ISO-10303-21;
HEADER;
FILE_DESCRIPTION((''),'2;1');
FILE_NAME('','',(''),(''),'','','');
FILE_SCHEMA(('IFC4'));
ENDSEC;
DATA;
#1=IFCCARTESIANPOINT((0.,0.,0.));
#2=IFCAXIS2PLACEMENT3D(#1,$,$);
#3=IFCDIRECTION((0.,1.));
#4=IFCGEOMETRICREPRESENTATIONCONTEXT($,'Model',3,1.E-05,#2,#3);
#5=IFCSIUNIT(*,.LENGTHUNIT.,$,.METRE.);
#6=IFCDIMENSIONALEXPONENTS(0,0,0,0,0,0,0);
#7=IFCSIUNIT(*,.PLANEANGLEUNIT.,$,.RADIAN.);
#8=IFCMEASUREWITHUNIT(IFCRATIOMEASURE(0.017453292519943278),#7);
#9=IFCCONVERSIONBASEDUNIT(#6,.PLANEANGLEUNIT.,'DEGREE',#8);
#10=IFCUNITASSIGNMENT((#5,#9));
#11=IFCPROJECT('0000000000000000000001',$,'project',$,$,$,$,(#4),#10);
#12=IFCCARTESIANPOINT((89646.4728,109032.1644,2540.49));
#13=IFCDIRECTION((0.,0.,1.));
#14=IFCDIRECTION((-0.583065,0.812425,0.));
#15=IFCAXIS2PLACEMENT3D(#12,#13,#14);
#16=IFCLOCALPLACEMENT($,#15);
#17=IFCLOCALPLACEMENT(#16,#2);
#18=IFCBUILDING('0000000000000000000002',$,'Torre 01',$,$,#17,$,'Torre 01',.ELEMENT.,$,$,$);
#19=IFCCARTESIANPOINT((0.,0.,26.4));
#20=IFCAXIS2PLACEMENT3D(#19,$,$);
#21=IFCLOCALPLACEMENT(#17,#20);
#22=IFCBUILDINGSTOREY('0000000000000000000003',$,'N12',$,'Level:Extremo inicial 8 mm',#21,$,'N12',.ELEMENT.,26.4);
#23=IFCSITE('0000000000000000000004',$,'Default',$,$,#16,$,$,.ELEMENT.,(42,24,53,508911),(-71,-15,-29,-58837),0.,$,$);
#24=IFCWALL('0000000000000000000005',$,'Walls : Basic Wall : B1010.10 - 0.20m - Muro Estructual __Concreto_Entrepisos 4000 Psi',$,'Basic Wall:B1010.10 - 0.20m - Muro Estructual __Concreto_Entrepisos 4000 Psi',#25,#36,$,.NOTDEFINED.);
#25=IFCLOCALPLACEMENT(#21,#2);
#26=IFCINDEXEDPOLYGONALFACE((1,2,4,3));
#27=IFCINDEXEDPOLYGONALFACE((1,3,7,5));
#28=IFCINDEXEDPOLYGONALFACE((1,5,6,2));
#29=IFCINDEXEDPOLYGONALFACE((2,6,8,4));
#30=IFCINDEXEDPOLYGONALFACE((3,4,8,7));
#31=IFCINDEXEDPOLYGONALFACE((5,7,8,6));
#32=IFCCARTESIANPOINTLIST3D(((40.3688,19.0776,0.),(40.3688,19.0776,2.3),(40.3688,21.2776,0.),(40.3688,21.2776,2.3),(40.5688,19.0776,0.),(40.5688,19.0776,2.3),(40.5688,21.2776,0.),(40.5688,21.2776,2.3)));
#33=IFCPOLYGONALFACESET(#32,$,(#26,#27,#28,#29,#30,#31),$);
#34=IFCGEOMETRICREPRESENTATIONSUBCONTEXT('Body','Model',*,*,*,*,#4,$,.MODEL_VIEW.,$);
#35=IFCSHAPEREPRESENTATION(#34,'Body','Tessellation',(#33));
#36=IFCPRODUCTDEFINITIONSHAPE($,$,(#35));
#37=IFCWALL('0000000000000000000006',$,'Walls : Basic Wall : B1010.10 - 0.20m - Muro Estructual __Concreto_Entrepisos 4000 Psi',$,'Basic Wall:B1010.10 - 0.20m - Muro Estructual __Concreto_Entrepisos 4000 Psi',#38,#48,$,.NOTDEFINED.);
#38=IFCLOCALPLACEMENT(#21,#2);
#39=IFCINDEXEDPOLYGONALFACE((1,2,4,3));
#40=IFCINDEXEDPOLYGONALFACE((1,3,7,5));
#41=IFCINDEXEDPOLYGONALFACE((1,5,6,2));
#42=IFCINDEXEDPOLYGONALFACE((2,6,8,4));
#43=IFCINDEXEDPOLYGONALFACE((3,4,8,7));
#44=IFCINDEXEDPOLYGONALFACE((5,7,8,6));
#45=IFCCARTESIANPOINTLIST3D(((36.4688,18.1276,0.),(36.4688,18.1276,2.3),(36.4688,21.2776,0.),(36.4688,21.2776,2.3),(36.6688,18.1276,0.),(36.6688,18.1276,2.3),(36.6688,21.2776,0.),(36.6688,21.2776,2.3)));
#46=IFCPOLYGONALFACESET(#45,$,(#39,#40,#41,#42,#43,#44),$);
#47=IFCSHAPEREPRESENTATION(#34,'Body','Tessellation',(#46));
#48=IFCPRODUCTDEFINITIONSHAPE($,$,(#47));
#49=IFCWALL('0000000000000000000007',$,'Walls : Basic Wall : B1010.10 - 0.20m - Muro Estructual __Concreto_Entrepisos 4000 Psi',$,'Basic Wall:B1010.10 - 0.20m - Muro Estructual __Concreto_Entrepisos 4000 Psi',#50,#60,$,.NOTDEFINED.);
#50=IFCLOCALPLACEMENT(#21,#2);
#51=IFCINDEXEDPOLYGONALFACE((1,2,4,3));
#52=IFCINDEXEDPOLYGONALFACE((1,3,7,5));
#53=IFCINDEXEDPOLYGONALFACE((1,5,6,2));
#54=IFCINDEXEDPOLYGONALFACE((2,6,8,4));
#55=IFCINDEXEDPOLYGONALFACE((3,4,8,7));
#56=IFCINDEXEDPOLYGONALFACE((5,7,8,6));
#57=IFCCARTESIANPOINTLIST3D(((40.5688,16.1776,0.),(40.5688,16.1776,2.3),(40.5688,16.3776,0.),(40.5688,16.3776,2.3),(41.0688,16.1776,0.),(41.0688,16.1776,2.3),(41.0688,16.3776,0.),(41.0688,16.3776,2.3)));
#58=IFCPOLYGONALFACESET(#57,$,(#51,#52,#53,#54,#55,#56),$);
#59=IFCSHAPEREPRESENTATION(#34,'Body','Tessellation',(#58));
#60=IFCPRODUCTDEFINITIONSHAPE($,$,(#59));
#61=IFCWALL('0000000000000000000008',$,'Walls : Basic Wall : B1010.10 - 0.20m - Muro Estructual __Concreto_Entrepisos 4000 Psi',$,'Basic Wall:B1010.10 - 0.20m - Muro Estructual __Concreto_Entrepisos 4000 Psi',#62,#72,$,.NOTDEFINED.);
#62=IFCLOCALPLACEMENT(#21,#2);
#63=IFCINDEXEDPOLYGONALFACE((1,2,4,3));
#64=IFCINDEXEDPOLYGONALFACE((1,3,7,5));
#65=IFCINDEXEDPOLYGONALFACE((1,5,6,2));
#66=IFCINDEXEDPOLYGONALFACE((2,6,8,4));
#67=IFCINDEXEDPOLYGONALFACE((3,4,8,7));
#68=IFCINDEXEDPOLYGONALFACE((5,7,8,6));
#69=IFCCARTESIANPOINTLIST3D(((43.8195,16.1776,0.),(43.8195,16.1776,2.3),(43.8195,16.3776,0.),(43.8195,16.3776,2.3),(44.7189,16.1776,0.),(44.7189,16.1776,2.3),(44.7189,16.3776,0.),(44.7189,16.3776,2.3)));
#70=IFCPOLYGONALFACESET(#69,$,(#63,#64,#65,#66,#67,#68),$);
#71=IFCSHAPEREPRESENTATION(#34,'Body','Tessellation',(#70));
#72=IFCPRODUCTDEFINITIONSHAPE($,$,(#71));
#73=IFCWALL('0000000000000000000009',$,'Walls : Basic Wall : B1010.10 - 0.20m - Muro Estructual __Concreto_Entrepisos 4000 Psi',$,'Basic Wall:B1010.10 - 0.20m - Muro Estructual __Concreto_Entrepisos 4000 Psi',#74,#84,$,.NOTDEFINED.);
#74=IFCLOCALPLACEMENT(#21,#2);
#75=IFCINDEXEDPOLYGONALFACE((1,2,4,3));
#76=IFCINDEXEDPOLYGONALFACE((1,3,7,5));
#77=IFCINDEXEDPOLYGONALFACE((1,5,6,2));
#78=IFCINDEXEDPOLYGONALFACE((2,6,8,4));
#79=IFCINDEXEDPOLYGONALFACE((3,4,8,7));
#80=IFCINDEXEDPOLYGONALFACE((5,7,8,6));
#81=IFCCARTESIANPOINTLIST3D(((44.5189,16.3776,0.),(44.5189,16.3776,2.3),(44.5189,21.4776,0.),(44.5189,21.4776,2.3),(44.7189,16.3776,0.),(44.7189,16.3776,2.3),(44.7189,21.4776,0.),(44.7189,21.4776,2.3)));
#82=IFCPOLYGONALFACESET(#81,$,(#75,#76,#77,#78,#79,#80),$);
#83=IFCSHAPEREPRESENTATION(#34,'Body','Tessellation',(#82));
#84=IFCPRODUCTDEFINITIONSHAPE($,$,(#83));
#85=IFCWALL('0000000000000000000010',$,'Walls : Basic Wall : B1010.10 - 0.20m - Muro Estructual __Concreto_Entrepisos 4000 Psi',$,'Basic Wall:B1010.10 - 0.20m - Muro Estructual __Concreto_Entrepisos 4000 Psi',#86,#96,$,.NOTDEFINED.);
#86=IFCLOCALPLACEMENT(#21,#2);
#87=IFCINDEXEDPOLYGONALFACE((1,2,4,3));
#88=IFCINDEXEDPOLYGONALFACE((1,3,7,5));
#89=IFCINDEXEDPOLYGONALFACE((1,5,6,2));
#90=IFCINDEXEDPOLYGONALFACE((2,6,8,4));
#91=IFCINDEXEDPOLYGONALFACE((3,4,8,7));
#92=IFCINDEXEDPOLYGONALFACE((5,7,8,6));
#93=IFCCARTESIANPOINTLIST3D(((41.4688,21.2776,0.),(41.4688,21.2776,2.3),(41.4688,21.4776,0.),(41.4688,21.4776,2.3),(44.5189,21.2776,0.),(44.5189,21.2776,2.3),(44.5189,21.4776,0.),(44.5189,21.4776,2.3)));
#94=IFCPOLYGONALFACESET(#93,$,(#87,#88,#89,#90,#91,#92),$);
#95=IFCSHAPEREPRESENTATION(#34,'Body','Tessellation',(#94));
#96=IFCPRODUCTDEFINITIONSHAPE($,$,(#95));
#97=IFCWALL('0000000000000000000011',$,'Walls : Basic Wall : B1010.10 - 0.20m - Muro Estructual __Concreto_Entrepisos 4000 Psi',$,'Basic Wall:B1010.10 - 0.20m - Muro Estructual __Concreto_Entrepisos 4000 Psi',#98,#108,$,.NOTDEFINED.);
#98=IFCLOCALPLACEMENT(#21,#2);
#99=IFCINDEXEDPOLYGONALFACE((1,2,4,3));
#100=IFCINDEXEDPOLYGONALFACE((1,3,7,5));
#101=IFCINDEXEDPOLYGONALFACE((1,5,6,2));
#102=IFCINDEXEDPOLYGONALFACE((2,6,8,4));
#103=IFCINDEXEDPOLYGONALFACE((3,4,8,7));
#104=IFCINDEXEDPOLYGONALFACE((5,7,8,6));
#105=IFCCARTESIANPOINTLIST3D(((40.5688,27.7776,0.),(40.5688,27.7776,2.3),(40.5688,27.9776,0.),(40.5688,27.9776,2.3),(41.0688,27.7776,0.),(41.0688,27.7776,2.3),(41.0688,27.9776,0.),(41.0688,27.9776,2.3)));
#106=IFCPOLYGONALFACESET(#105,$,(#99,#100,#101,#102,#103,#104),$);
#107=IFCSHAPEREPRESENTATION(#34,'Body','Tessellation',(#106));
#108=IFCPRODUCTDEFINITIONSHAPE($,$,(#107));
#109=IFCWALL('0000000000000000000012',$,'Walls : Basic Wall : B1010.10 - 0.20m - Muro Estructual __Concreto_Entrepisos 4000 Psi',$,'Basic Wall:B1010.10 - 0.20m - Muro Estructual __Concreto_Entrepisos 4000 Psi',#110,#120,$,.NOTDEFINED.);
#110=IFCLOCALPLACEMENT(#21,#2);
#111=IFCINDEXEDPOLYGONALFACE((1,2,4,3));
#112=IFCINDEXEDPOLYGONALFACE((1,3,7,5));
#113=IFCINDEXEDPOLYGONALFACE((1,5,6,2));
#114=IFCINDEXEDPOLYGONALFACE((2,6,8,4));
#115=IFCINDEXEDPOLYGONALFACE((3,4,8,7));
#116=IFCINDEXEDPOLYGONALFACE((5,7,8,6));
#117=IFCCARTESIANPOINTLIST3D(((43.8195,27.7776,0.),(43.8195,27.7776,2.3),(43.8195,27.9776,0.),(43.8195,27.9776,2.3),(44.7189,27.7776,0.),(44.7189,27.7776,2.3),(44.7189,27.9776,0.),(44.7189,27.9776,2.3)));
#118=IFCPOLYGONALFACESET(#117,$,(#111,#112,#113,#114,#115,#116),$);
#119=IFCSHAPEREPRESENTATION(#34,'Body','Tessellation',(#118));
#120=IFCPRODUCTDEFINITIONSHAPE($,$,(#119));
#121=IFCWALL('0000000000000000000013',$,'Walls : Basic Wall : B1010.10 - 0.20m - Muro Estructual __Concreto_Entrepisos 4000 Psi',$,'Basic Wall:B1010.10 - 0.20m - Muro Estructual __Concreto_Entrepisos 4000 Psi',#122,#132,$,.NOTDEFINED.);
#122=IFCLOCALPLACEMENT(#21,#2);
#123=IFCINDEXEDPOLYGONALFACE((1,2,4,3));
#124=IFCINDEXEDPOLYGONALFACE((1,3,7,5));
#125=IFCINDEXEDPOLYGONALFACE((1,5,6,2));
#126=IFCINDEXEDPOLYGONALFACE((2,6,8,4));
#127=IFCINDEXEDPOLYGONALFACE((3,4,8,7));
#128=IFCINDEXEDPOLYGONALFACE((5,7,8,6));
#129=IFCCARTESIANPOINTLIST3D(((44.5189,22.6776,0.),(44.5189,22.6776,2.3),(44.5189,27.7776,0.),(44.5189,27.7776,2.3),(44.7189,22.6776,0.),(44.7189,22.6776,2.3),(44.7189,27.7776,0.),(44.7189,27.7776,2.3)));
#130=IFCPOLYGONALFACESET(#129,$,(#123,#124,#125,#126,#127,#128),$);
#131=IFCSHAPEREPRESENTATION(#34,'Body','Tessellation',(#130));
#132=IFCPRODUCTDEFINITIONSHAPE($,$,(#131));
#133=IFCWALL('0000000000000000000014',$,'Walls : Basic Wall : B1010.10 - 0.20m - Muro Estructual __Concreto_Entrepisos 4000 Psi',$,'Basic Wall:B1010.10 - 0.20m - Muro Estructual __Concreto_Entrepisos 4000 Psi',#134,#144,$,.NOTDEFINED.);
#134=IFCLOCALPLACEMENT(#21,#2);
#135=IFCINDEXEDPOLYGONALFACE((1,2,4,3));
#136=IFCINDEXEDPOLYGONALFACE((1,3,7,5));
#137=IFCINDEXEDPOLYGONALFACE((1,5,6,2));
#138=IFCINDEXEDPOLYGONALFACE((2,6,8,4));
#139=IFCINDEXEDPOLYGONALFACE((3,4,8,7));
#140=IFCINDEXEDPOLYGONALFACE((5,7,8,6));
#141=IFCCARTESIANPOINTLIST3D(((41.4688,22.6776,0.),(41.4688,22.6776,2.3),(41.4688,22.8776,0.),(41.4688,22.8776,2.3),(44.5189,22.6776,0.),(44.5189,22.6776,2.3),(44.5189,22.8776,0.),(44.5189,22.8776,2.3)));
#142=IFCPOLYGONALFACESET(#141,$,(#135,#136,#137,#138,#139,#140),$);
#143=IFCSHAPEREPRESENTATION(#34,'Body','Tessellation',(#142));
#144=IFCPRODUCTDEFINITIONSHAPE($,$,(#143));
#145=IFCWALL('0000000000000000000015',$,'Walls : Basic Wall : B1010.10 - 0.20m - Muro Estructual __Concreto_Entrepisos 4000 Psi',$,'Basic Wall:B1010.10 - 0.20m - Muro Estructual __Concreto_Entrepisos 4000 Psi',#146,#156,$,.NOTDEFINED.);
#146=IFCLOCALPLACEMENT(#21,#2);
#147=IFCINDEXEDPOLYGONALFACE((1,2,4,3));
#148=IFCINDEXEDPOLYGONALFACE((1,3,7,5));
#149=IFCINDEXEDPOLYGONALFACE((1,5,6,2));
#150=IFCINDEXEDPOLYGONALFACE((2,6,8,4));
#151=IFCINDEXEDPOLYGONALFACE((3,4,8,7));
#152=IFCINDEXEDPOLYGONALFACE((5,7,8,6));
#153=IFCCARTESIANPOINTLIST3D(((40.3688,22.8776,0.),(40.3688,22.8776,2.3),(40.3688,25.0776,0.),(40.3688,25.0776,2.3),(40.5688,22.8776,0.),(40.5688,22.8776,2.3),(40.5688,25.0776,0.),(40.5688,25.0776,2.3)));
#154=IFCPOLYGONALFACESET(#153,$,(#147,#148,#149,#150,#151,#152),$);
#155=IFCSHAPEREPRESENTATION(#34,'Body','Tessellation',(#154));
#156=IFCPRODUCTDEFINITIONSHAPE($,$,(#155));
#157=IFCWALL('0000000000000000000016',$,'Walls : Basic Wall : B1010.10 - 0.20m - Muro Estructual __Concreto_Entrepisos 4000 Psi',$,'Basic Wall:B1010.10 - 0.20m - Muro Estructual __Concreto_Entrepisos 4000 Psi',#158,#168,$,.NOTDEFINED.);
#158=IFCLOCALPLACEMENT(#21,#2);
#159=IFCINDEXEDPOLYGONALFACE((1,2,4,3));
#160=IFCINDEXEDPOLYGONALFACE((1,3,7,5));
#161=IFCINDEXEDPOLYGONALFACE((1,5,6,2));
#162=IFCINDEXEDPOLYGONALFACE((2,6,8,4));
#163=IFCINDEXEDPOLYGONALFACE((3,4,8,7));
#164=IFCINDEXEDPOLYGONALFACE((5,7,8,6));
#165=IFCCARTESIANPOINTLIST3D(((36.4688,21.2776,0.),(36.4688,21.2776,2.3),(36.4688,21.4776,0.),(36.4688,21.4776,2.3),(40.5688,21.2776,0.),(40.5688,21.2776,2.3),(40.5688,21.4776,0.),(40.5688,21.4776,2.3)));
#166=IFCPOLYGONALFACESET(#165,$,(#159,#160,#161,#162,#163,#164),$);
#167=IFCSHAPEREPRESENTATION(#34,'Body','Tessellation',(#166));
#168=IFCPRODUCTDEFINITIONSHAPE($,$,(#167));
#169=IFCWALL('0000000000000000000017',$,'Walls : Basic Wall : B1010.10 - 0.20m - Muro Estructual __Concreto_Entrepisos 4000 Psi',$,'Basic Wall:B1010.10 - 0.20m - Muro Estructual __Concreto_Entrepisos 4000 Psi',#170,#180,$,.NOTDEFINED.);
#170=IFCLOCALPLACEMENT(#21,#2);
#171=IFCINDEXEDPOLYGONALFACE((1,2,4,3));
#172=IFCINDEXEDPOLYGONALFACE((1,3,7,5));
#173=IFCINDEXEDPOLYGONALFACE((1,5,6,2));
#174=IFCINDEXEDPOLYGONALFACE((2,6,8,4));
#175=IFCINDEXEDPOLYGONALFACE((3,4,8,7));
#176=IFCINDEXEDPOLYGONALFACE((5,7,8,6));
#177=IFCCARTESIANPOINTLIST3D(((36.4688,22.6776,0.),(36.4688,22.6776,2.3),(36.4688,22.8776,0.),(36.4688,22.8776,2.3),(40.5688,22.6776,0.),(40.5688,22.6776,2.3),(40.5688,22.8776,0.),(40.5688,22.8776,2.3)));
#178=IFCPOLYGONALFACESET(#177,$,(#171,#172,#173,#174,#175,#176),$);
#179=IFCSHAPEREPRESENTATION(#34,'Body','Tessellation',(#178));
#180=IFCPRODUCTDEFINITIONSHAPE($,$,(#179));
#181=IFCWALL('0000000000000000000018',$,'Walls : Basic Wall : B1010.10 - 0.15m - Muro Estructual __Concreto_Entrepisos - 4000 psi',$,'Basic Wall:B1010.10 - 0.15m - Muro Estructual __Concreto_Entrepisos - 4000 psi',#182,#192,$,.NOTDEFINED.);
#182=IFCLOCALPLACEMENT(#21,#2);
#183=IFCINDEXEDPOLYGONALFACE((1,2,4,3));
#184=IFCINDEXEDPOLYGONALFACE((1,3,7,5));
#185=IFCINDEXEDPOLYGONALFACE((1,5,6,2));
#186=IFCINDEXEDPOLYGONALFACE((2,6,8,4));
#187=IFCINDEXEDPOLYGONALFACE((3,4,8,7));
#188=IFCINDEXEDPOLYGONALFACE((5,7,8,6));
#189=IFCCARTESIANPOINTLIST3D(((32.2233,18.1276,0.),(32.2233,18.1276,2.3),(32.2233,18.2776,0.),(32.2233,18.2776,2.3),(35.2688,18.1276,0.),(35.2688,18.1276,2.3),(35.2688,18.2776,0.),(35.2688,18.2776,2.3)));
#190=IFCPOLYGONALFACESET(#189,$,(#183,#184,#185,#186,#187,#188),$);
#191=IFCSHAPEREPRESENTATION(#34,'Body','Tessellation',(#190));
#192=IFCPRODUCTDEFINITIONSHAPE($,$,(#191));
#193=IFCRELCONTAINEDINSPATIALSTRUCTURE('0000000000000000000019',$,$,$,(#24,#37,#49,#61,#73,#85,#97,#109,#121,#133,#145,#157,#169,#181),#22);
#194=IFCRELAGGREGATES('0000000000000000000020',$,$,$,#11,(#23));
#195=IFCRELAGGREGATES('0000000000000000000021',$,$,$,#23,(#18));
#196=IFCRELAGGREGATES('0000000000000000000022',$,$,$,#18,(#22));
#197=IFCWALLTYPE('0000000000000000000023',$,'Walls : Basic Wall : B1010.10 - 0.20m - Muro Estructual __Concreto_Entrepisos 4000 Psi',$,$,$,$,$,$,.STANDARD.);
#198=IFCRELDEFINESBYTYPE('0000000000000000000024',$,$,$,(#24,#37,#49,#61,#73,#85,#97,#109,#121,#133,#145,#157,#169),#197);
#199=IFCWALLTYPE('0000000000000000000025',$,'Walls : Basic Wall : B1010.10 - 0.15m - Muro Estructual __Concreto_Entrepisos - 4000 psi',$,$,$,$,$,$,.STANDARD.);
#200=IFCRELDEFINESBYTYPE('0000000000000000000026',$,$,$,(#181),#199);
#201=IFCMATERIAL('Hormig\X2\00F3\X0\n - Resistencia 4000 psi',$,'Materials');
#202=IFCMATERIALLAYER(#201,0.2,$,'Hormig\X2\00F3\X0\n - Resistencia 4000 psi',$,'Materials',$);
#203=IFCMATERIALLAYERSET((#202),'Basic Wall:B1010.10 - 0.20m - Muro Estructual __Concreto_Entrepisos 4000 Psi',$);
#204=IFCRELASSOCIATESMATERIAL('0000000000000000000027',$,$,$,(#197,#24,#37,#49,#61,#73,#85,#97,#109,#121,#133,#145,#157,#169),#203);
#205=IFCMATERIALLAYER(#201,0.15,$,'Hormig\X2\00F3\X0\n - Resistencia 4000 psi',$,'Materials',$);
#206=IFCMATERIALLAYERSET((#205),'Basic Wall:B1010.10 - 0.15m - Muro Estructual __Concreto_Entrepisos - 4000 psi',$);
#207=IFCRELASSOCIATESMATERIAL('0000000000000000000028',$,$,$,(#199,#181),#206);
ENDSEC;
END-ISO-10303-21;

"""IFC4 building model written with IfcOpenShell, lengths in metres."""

from ifc_helpers import new_model, entity, si_unit, converted_unit, direction, frame, frame_2d, origin, place, context, subcontext, project, spatial, rectangle, extrude, material, layer, layer_set, layer_usage, type_object, element, save


model = new_model("IFC4")

# Units and contexts
model_context = context("Model", 3, precision=1e-05, world=origin(), true_north=direction((0.0, 1.0)))
body_context = subcontext(model_context, "Body", "Model", "MODEL_VIEW")
ifc_project = project(units=[si_unit("LENGTHUNIT", "METRE"), converted_unit("PLANEANGLEUNIT", "DEGREE", entity("IfcRatioMeasure", 0.017453292519943278), si_unit("PLANEANGLEUNIT", "RADIAN"), dimensions=[0, 0, 0, 0, 0, 0, 0])], contexts=[model_context])

# Site, building, storey
site_placement = place(None, frame((89646.4728, 109032.1644, 2540.49), z_axis=(0.0, 0.0, 1.0), x_axis=(-0.583065, 0.812425, 0.0)))
site = spatial("IfcSite", under=ifc_project, at=site_placement, Name="Default", CompositionType="ELEMENT", RefLatitude=(42, 24, 53, 508911), RefLongitude=(-71, -15, -29, -58837), RefElevation=0.0)
building_placement = place(site_placement, origin())
building = spatial("IfcBuilding", under=site, at=building_placement, Name="Torre 01", LongName="Torre 01", CompositionType="ELEMENT")
storey_placement = place(building_placement, frame((0.0, 0.0, 26.4)))
storey = spatial("IfcBuildingStorey", under=building, at=storey_placement, Name="N12", ObjectType="Level:Extremo inicial 8 mm", LongName="N12", CompositionType="ELEMENT", Elevation=26.4)

# Walls
ifc_material = material(Name="Hormigón - Resistencia 4000 psi", Category="Materials")
ifc_layer_1 = layer(ifc_material, 0.2, Name="Hormigón - Resistencia 4000 psi", Category="Materials")
ifc_layer_set_1 = layer_set([ifc_layer_1], Name="Basic Wall:B1010.10 - 0.20m - Muro Estructual __Concreto_Entrepisos 4000 Psi")
ifc_layer_usage_1 = layer_usage(ifc_layer_set_1, "AXIS2", "NEGATIVE", 0.1)
wall_type_1 = type_object("IfcWallType", Name="Walls : Basic Wall : B1010.10 - 0.20m - Muro Estructual __Concreto_Entrepisos 4000 Psi", PredefinedType="STANDARD", material=ifc_layer_set_1)
wall_1_placement = place(storey_placement, frame((40.4688, 21.2776, 0.0), z_axis=(0.0, 0.0, 1.0), x_axis=(0.0, -1.0, 0.0)))
element("IfcWall", 1, at=wall_1_placement, inside=storey, type_object=wall_type_1, material=ifc_layer_usage_1, Name="Walls : Basic Wall : B1010.10 - 0.20m - Muro Estructual __Concreto_Entrepisos 4000 Psi", ObjectType="Basic Wall:B1010.10 - 0.20m - Muro Estructual __Concreto_Entrepisos 4000 Psi", PredefinedType="NOTDEFINED", context=body_context, shape_type="SweptSolid", body=[
    extrude(rectangle(XDim=2.2, YDim=0.2, at=frame_2d((1.1, 0.0), x_axis=(-1.0, 0.0))), origin(), (0.0, 0.0, 1.0), 2.3),
])
ifc_layer_usage_2 = layer_usage(ifc_layer_set_1, "AXIS2", "NEGATIVE", 0.1)
wall_2_placement = place(storey_placement, frame((36.5688, 18.1276, 0.0), z_axis=(0.0, 0.0, 1.0), x_axis=(0.0, 1.0, 0.0)))
element("IfcWall", 2, at=wall_2_placement, inside=storey, type_object=wall_type_1, material=ifc_layer_usage_2, Name="Walls : Basic Wall : B1010.10 - 0.20m - Muro Estructual __Concreto_Entrepisos 4000 Psi", ObjectType="Basic Wall:B1010.10 - 0.20m - Muro Estructual __Concreto_Entrepisos 4000 Psi", PredefinedType="NOTDEFINED", context=body_context, shape_type="SweptSolid", body=[
    extrude(rectangle(XDim=3.15, YDim=0.2, at=frame_2d((1.575, 0.0), x_axis=(-1.0, 0.0))), origin(), (0.0, 0.0, 1.0), 2.3),
])
ifc_layer_usage_3 = layer_usage(ifc_layer_set_1, "AXIS2", "NEGATIVE", 0.1)
wall_3_placement = place(storey_placement, frame((41.0688, 16.2776, 0.0), z_axis=(0.0, 0.0, 1.0), x_axis=(-1.0, 0.0, 0.0)))
element("IfcWall", 3, at=wall_3_placement, inside=storey, type_object=wall_type_1, material=ifc_layer_usage_3, Name="Walls : Basic Wall : B1010.10 - 0.20m - Muro Estructual __Concreto_Entrepisos 4000 Psi", ObjectType="Basic Wall:B1010.10 - 0.20m - Muro Estructual __Concreto_Entrepisos 4000 Psi", PredefinedType="NOTDEFINED", context=body_context, shape_type="SweptSolid", body=[
    extrude(rectangle(XDim=0.5, YDim=0.2, at=frame_2d((0.25, 0.0), x_axis=(-1.0, 0.0))), origin(), (0.0, 0.0, 1.0), 2.3),
])
ifc_layer_usage_4 = layer_usage(ifc_layer_set_1, "AXIS2", "NEGATIVE", 0.1)
wall_4_placement = place(storey_placement, frame((43.8195, 16.2776, 0.0)))
element("IfcWall", 4, at=wall_4_placement, inside=storey, type_object=wall_type_1, material=ifc_layer_usage_4, Name="Walls : Basic Wall : B1010.10 - 0.20m - Muro Estructual __Concreto_Entrepisos 4000 Psi", ObjectType="Basic Wall:B1010.10 - 0.20m - Muro Estructual __Concreto_Entrepisos 4000 Psi", PredefinedType="NOTDEFINED", context=body_context, shape_type="SweptSolid", body=[
    extrude(rectangle(XDim=0.8993, YDim=0.2, at=frame_2d((0.4497, 0.0), x_axis=(-1.0, 0.0))), origin(), (0.0, 0.0, 1.0), 2.3),
])
ifc_layer_usage_5 = layer_usage(ifc_layer_set_1, "AXIS2", "NEGATIVE", 0.1)
wall_5_placement = place(storey_placement, frame((44.6189, 21.4776, 0.0), z_axis=(0.0, 0.0, 1.0), x_axis=(0.0, -1.0, 0.0)))
element("IfcWall", 5, at=wall_5_placement, inside=storey, type_object=wall_type_1, material=ifc_layer_usage_5, Name="Walls : Basic Wall : B1010.10 - 0.20m - Muro Estructual __Concreto_Entrepisos 4000 Psi", ObjectType="Basic Wall:B1010.10 - 0.20m - Muro Estructual __Concreto_Entrepisos 4000 Psi", PredefinedType="NOTDEFINED", context=body_context, shape_type="SweptSolid", body=[
    extrude(rectangle(XDim=5.1, YDim=0.2, at=frame_2d((2.55, 0.0), x_axis=(-1.0, 0.0))), origin(), (0.0, 0.0, 1.0), 2.3),
])
ifc_layer_usage_6 = layer_usage(ifc_layer_set_1, "AXIS2", "NEGATIVE", 0.1)
wall_6_placement = place(storey_placement, frame((41.4688, 21.3776, 0.0)))
element("IfcWall", 6, at=wall_6_placement, inside=storey, type_object=wall_type_1, material=ifc_layer_usage_6, Name="Walls : Basic Wall : B1010.10 - 0.20m - Muro Estructual __Concreto_Entrepisos 4000 Psi", ObjectType="Basic Wall:B1010.10 - 0.20m - Muro Estructual __Concreto_Entrepisos 4000 Psi", PredefinedType="NOTDEFINED", context=body_context, shape_type="SweptSolid", body=[
    extrude(rectangle(XDim=3.05, YDim=0.2, at=frame_2d((1.525, 0.0), x_axis=(-1.0, 0.0))), origin(), (0.0, 0.0, 1.0), 2.3),
])
ifc_layer_usage_7 = layer_usage(ifc_layer_set_1, "AXIS2", "POSITIVE", -0.1)
wall_7_placement = place(storey_placement, frame((41.0688, 27.8776, 0.0), z_axis=(0.0, 0.0, 1.0), x_axis=(-1.0, 0.0, 0.0)))
element("IfcWall", 7, at=wall_7_placement, inside=storey, type_object=wall_type_1, material=ifc_layer_usage_7, Name="Walls : Basic Wall : B1010.10 - 0.20m - Muro Estructual __Concreto_Entrepisos 4000 Psi", ObjectType="Basic Wall:B1010.10 - 0.20m - Muro Estructual __Concreto_Entrepisos 4000 Psi", PredefinedType="NOTDEFINED", context=body_context, shape_type="SweptSolid", body=[
    extrude(rectangle(XDim=0.5, YDim=0.2, at=frame_2d((0.25, 0.0), x_axis=(-1.0, 0.0))), origin(), (0.0, 0.0, 1.0), 2.3),
])
ifc_layer_usage_8 = layer_usage(ifc_layer_set_1, "AXIS2", "POSITIVE", -0.1)
wall_8_placement = place(storey_placement, frame((43.8195, 27.8776, 0.0)))
element("IfcWall", 8, at=wall_8_placement, inside=storey, type_object=wall_type_1, material=ifc_layer_usage_8, Name="Walls : Basic Wall : B1010.10 - 0.20m - Muro Estructual __Concreto_Entrepisos 4000 Psi", ObjectType="Basic Wall:B1010.10 - 0.20m - Muro Estructual __Concreto_Entrepisos 4000 Psi", PredefinedType="NOTDEFINED", context=body_context, shape_type="SweptSolid", body=[
    extrude(rectangle(XDim=0.8993, YDim=0.2, at=frame_2d((0.4497, 0.0), x_axis=(-1.0, 0.0))), origin(), (0.0, 0.0, 1.0), 2.3),
])
ifc_layer_usage_9 = layer_usage(ifc_layer_set_1, "AXIS2", "POSITIVE", -0.1)
wall_9_placement = place(storey_placement, frame((44.6189, 22.6776, 0.0), z_axis=(0.0, 0.0, 1.0), x_axis=(0.0, 1.0, 0.0)))
element("IfcWall", 9, at=wall_9_placement, inside=storey, type_object=wall_type_1, material=ifc_layer_usage_9, Name="Walls : Basic Wall : B1010.10 - 0.20m - Muro Estructual __Concreto_Entrepisos 4000 Psi", ObjectType="Basic Wall:B1010.10 - 0.20m - Muro Estructual __Concreto_Entrepisos 4000 Psi", PredefinedType="NOTDEFINED", context=body_context, shape_type="SweptSolid", body=[
    extrude(rectangle(XDim=5.1, YDim=0.2, at=frame_2d((2.55, 0.0), x_axis=(-1.0, 0.0))), origin(), (0.0, 0.0, 1.0), 2.3),
])
ifc_layer_usage_10 = layer_usage(ifc_layer_set_1, "AXIS2", "POSITIVE", -0.1)
wall_10_placement = place(storey_placement, frame((41.4688, 22.7776, 0.0)))
element("IfcWall", 10, at=wall_10_placement, inside=storey, type_object=wall_type_1, material=ifc_layer_usage_10, Name="Walls : Basic Wall : B1010.10 - 0.20m - Muro Estructual __Concreto_Entrepisos 4000 Psi", ObjectType="Basic Wall:B1010.10 - 0.20m - Muro Estructual __Concreto_Entrepisos 4000 Psi", PredefinedType="NOTDEFINED", context=body_context, shape_type="SweptSolid", body=[
    extrude(rectangle(XDim=3.05, YDim=0.2, at=frame_2d((1.525, 0.0), x_axis=(-1.0, 0.0))), origin(), (0.0, 0.0, 1.0), 2.3),
])
ifc_layer_usage_11 = layer_usage(ifc_layer_set_1, "AXIS2", "POSITIVE", -0.1)
wall_11_placement = place(storey_placement, frame((40.4688, 22.8776, 0.0), z_axis=(0.0, 0.0, 1.0), x_axis=(0.0, 1.0, 0.0)))
element("IfcWall", 11, at=wall_11_placement, inside=storey, type_object=wall_type_1, material=ifc_layer_usage_11, Name="Walls : Basic Wall : B1010.10 - 0.20m - Muro Estructual __Concreto_Entrepisos 4000 Psi", ObjectType="Basic Wall:B1010.10 - 0.20m - Muro Estructual __Concreto_Entrepisos 4000 Psi", PredefinedType="NOTDEFINED", context=body_context, shape_type="SweptSolid", body=[
    extrude(rectangle(XDim=2.2, YDim=0.2, at=frame_2d((1.1, 0.0), x_axis=(-1.0, 0.0))), origin(), (0.0, 0.0, 1.0), 2.3),
])
ifc_layer_usage_12 = layer_usage(ifc_layer_set_1, "AXIS2", "NEGATIVE", 0.1)
wall_12_placement = place(storey_placement, frame((36.4688, 21.3776, 0.0)))
element("IfcWall", 12, at=wall_12_placement, inside=storey, type_object=wall_type_1, material=ifc_layer_usage_12, Name="Walls : Basic Wall : B1010.10 - 0.20m - Muro Estructual __Concreto_Entrepisos 4000 Psi", ObjectType="Basic Wall:B1010.10 - 0.20m - Muro Estructual __Concreto_Entrepisos 4000 Psi", PredefinedType="NOTDEFINED", context=body_context, shape_type="SweptSolid", body=[
    extrude(rectangle(XDim=4.1, YDim=0.2, at=frame_2d((2.05, 0.0), x_axis=(-1.0, 0.0))), origin(), (0.0, 0.0, 1.0), 2.3),
])
ifc_layer_usage_13 = layer_usage(ifc_layer_set_1, "AXIS2", "POSITIVE", -0.1)
wall_13_placement = place(storey_placement, frame((36.4688, 22.7776, 0.0)))
element("IfcWall", 13, at=wall_13_placement, inside=storey, type_object=wall_type_1, material=ifc_layer_usage_13, Name="Walls : Basic Wall : B1010.10 - 0.20m - Muro Estructual __Concreto_Entrepisos 4000 Psi", ObjectType="Basic Wall:B1010.10 - 0.20m - Muro Estructual __Concreto_Entrepisos 4000 Psi", PredefinedType="NOTDEFINED", context=body_context, shape_type="SweptSolid", body=[
    extrude(rectangle(XDim=4.1, YDim=0.2, at=frame_2d((2.05, 0.0), x_axis=(-1.0, 0.0))), origin(), (0.0, 0.0, 1.0), 2.3),
])
ifc_layer_2 = layer(ifc_material, 0.15, Name="Hormigón - Resistencia 4000 psi", Category="Materials")
ifc_layer_set_2 = layer_set([ifc_layer_2], Name="Basic Wall:B1010.10 - 0.15m - Muro Estructual __Concreto_Entrepisos - 4000 psi")
ifc_layer_usage_14 = layer_usage(ifc_layer_set_2, "AXIS2", "NEGATIVE", 0.075)
wall_type_2 = type_object("IfcWallType", Name="Walls : Basic Wall : B1010.10 - 0.15m - Muro Estructual __Concreto_Entrepisos - 4000 psi", PredefinedType="STANDARD", material=ifc_layer_set_2)
wall_14_placement = place(storey_placement, frame((32.2233, 18.2026, 0.0)))
element("IfcWall", 14, at=wall_14_placement, inside=storey, type_object=wall_type_2, material=ifc_layer_usage_14, Name="Walls : Basic Wall : B1010.10 - 0.15m - Muro Estructual __Concreto_Entrepisos - 4000 psi", ObjectType="Basic Wall:B1010.10 - 0.15m - Muro Estructual __Concreto_Entrepisos - 4000 psi", PredefinedType="NOTDEFINED", context=body_context, shape_type="SweptSolid", body=[
    extrude(rectangle(XDim=3.0455, YDim=0.15, at=frame_2d((1.5228, 0.0), x_axis=(-1.0, 0.0))), origin(), (0.0, 0.0, 1.0), 2.3),
])

save(model, "model.ifc")
